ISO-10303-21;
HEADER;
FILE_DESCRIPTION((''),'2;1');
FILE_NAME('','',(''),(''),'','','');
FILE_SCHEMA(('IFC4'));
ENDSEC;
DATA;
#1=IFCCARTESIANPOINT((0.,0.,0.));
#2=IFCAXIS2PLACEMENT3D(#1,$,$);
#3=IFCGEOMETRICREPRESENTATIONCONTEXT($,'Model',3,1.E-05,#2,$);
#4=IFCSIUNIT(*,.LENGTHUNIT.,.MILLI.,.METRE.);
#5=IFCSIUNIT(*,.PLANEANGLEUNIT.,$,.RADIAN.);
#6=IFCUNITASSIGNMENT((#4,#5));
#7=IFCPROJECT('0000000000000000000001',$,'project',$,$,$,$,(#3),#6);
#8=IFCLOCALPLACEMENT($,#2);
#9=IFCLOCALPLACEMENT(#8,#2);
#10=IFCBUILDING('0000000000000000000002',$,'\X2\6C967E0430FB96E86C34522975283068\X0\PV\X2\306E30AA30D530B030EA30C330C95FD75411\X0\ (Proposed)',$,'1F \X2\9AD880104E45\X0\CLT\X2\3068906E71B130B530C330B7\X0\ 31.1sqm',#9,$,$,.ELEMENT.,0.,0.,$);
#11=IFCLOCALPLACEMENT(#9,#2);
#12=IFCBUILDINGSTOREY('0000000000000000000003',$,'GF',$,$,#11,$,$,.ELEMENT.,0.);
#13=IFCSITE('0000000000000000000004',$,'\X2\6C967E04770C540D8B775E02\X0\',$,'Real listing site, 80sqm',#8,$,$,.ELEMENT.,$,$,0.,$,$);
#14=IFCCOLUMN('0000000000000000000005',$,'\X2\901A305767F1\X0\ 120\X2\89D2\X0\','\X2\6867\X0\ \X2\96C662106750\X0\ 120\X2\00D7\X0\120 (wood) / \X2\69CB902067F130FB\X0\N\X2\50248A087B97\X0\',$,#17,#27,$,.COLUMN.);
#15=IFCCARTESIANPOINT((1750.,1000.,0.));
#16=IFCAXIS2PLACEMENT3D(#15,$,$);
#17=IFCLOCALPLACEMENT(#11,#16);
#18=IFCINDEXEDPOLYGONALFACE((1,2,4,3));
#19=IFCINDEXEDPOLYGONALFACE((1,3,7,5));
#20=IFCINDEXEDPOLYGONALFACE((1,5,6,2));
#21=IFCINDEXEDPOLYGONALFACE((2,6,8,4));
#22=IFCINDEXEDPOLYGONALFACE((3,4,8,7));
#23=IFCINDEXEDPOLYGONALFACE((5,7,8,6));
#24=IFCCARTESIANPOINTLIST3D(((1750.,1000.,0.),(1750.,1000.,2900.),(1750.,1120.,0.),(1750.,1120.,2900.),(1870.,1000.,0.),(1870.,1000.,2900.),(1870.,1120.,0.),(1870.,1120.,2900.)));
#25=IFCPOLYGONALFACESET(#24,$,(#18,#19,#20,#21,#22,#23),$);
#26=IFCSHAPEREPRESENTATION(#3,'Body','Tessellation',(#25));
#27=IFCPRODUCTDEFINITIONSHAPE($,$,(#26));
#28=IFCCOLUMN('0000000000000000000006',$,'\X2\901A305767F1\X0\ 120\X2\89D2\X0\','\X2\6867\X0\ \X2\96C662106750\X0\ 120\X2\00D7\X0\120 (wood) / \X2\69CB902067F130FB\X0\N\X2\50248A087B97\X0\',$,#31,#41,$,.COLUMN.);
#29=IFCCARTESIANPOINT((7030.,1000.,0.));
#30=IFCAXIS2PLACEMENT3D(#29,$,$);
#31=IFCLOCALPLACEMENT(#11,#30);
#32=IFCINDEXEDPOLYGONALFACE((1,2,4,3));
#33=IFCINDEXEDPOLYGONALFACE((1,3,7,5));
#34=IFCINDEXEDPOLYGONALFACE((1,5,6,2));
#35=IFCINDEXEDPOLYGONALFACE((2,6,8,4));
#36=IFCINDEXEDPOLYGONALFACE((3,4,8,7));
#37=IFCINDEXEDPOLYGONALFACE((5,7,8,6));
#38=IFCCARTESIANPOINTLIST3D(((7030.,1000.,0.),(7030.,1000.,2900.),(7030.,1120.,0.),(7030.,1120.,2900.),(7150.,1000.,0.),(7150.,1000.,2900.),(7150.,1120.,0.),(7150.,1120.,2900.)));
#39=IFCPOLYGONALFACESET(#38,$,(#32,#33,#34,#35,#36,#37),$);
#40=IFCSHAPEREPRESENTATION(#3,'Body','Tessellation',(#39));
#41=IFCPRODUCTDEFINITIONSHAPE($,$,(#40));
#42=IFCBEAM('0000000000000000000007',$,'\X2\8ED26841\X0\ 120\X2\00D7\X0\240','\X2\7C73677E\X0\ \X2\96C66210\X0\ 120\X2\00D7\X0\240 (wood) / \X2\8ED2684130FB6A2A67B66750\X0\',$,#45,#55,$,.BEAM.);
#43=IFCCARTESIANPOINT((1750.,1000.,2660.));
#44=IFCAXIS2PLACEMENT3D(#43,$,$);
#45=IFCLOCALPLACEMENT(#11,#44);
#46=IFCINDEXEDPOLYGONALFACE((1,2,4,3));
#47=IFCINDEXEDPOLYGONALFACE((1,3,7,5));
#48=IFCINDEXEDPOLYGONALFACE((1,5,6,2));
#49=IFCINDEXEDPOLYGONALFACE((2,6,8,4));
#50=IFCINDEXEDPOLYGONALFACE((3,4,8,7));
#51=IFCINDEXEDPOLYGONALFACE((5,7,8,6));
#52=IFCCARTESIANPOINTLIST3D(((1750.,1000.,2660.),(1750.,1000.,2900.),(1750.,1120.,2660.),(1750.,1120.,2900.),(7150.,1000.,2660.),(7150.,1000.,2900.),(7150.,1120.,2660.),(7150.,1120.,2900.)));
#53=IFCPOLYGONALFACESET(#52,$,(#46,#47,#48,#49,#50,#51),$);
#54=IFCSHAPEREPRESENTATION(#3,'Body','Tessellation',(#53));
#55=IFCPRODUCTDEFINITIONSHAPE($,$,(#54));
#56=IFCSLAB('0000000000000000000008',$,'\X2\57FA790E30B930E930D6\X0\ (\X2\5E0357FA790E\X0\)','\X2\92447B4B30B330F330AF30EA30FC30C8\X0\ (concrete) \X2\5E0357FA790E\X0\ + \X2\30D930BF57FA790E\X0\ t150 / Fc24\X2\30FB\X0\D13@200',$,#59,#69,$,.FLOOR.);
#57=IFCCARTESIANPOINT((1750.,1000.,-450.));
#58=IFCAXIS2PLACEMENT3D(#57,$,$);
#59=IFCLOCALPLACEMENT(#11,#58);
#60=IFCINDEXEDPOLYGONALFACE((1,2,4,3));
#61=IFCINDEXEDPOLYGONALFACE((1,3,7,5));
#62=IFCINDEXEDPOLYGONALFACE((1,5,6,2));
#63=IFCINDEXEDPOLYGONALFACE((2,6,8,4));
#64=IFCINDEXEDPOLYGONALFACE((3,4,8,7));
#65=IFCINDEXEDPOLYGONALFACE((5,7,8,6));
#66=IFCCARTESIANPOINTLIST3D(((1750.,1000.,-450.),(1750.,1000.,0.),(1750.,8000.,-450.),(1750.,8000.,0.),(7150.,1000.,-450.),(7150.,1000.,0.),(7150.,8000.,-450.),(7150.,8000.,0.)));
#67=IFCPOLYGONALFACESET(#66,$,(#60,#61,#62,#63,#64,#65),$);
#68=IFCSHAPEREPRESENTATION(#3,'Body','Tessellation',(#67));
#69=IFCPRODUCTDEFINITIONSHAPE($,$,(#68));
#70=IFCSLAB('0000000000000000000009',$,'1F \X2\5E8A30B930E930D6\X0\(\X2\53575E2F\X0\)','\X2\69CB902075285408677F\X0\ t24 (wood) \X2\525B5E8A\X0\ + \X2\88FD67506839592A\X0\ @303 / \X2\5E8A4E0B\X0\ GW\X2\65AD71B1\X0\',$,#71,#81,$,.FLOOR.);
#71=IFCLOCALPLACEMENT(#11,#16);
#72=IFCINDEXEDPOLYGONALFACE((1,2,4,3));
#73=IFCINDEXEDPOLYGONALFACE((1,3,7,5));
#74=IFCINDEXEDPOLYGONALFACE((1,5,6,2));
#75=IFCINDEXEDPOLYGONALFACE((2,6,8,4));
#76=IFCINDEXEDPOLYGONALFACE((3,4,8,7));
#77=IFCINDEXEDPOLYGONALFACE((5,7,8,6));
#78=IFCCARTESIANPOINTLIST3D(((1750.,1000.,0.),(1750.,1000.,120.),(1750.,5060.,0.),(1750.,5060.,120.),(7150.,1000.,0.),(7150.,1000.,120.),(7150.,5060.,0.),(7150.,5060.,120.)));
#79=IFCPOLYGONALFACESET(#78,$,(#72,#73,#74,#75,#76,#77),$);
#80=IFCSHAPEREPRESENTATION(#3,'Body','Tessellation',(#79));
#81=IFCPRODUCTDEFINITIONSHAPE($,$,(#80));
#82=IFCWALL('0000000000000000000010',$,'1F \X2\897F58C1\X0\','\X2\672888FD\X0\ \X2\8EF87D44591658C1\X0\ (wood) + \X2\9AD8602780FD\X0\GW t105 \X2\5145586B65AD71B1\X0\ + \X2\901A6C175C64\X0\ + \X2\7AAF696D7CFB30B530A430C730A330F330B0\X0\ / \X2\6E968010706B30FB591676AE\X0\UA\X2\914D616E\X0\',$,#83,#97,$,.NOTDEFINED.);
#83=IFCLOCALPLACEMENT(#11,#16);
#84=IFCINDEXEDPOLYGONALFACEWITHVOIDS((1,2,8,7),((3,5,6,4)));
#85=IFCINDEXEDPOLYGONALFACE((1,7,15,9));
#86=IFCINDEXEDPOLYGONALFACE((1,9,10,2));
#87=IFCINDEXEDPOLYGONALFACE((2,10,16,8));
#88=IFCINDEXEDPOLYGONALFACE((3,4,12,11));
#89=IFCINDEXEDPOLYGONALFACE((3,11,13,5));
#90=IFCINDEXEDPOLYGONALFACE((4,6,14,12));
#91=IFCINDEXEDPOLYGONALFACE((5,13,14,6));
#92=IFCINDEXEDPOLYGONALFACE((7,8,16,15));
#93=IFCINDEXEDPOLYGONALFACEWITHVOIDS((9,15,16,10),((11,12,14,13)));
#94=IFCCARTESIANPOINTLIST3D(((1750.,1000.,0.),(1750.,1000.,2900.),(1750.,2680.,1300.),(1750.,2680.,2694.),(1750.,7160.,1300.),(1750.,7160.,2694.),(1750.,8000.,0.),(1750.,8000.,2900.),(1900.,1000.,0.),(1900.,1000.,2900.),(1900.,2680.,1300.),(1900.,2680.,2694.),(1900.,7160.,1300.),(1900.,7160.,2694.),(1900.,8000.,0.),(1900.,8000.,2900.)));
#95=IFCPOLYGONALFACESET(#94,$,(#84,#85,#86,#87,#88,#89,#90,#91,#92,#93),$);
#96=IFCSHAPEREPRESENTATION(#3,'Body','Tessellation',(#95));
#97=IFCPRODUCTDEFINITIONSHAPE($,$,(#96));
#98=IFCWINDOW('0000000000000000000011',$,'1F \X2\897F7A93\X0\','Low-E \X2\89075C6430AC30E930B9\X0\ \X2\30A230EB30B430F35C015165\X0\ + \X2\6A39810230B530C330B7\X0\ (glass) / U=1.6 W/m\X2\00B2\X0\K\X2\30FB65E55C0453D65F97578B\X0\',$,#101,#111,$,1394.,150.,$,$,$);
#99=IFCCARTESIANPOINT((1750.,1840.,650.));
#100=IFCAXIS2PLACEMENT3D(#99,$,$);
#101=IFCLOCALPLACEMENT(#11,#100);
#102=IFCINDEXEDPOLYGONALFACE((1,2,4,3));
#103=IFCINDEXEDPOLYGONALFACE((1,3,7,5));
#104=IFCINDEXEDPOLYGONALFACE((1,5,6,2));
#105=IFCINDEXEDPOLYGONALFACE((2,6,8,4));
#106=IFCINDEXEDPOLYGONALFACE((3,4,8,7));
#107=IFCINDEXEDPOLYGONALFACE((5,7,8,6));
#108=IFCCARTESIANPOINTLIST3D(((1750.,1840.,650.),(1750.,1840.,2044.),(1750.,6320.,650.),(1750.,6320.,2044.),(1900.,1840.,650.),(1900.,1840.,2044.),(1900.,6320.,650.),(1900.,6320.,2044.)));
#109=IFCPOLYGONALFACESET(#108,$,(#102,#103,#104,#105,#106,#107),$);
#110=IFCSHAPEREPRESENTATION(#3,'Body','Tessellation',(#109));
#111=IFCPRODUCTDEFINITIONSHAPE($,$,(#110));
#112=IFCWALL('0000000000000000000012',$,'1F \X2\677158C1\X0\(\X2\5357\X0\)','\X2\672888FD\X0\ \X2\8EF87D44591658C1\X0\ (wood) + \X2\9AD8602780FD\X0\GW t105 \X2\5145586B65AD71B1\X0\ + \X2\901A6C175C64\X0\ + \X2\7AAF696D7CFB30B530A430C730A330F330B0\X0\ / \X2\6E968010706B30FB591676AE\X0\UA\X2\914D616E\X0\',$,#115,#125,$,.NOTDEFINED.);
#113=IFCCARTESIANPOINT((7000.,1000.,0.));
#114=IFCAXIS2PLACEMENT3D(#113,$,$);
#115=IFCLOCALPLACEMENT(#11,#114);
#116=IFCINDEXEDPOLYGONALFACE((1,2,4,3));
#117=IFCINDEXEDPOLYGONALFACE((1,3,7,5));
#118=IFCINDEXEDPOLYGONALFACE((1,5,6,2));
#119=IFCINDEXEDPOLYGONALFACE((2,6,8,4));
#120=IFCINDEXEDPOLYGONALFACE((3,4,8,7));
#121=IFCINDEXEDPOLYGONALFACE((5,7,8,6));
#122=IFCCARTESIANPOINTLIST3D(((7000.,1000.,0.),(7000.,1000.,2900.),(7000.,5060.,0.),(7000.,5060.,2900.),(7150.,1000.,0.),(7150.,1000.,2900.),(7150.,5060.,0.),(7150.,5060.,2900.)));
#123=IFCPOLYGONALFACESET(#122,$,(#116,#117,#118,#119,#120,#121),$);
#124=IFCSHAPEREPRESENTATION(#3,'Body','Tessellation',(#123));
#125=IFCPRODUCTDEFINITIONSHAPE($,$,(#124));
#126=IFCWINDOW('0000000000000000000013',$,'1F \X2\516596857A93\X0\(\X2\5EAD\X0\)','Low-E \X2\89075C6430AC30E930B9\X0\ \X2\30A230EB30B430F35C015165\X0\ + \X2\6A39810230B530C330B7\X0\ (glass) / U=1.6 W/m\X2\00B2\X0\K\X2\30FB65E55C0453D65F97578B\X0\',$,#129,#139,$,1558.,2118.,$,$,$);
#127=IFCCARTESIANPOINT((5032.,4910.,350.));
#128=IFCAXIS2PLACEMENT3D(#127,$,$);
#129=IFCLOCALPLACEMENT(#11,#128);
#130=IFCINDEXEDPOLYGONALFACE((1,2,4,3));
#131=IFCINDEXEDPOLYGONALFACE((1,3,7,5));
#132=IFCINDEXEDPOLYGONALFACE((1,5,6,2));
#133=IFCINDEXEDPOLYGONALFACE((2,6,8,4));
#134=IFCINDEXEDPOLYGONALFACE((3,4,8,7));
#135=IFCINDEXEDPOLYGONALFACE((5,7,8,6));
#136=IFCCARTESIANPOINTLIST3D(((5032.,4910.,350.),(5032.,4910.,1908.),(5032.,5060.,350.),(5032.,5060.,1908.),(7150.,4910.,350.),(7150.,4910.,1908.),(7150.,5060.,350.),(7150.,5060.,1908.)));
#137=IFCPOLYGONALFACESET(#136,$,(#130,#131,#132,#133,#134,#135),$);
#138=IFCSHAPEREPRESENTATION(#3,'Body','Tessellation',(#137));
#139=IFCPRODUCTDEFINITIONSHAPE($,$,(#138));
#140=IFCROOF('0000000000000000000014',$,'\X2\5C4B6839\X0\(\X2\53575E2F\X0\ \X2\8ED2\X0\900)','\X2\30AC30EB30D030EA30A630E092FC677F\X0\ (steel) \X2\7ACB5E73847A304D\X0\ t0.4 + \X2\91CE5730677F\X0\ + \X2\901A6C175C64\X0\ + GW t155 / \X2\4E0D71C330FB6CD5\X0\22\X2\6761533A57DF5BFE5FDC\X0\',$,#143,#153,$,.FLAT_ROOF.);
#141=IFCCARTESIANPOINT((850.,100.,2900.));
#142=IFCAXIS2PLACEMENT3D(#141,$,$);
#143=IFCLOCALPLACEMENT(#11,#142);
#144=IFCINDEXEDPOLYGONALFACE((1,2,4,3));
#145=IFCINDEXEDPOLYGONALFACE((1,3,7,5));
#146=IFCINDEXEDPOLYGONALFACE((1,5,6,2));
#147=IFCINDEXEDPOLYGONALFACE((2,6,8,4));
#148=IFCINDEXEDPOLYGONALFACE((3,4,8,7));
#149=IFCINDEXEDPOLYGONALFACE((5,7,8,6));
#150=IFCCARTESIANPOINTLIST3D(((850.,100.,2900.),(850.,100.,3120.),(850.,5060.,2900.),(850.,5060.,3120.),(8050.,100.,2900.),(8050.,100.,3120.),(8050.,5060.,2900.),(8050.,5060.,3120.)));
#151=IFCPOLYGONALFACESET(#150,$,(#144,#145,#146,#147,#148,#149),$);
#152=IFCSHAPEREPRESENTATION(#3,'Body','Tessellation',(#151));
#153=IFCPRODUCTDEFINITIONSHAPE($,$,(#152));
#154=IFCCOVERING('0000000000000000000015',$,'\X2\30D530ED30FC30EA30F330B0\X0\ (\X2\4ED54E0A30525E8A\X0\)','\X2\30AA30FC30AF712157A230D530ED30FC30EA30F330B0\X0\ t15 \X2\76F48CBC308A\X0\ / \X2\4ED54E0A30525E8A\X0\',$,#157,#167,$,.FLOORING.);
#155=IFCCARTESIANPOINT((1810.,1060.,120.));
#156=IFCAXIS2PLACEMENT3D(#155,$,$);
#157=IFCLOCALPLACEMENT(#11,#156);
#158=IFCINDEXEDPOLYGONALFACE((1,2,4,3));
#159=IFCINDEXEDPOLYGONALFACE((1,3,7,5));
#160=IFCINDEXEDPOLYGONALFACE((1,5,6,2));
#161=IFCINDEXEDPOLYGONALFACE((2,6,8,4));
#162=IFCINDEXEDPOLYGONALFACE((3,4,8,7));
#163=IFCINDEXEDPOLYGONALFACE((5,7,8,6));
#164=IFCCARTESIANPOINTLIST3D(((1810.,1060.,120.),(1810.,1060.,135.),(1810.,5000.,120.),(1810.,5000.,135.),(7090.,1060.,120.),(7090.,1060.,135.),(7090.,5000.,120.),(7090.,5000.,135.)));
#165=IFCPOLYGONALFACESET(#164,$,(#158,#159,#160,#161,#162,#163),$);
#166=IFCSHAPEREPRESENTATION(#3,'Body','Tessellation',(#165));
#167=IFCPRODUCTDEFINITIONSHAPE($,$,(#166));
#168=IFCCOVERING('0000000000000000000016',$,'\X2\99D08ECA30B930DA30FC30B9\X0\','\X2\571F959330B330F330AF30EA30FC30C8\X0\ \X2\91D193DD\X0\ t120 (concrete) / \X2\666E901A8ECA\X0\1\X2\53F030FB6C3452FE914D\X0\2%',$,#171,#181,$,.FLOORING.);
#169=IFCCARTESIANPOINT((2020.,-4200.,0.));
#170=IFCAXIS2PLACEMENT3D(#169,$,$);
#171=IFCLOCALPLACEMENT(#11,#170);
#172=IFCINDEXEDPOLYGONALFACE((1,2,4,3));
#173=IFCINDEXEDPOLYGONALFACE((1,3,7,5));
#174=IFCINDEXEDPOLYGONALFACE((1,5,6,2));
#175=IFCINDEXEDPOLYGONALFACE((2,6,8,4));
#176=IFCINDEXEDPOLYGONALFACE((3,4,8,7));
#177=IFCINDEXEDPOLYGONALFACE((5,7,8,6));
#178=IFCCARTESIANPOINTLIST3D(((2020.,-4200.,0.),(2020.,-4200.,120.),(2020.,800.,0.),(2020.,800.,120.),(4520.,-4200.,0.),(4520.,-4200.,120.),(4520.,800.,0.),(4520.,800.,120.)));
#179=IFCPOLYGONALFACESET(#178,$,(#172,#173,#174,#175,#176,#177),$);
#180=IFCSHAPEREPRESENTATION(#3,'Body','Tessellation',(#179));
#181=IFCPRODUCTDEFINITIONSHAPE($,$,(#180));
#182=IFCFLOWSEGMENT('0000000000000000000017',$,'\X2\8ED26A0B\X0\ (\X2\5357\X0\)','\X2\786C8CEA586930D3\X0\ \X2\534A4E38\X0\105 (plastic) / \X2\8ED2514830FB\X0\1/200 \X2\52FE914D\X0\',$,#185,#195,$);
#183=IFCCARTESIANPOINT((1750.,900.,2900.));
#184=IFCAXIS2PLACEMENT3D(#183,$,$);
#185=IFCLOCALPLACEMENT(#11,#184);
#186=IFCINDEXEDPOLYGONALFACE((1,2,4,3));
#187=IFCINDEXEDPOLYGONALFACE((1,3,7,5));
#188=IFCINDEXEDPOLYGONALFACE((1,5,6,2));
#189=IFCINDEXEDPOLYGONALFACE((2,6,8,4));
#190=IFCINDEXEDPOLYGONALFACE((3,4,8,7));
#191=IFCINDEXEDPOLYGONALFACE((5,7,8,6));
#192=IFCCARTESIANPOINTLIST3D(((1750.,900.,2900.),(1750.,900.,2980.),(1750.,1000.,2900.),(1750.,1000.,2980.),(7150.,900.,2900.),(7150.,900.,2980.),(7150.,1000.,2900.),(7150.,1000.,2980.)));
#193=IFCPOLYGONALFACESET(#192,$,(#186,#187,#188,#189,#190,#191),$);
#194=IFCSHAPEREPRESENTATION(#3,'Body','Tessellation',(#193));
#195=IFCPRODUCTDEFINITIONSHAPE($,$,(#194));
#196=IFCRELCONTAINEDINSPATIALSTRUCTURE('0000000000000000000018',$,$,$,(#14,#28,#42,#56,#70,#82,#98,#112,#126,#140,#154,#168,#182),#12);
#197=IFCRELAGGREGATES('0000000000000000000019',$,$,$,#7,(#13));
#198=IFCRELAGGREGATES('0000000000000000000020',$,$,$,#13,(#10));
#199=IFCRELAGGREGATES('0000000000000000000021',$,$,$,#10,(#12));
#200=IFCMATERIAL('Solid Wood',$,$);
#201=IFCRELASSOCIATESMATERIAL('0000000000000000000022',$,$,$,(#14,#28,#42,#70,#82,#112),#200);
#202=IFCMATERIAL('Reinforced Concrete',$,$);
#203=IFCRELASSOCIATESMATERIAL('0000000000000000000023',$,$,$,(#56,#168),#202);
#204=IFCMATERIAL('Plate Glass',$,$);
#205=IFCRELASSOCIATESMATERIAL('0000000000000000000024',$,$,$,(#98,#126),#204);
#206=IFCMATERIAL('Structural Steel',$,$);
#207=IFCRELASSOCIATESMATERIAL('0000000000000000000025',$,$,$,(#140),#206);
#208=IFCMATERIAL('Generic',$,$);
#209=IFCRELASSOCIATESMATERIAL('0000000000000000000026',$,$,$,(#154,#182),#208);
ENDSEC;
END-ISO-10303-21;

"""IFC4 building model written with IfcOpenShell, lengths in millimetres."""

from ifc_helpers import new_model, si_unit, frame, frame_2d, origin, place, context, project, spatial, rectangle, extrude, material, element, fill, save


model = new_model("IFC4")

# Units and contexts
model_context = context("Model", 3, precision=1e-05, world=origin())
ifc_project = project(units=[si_unit("LENGTHUNIT", "METRE", prefix="MILLI"), si_unit("PLANEANGLEUNIT", "RADIAN")], contexts=[model_context])

# Site, building, storey
site_placement = place(None, origin())
site = spatial("IfcSite", under=ifc_project, at=site_placement, Name="沖縄県名護市", ObjectType="Real listing site, 80sqm", CompositionType="ELEMENT", RefElevation=0.0)
building_placement = place(site_placement, origin())
building = spatial("IfcBuilding", under=site, at=building_placement, Name="沖縄・雨水利用とPVのオフグリッド志向 (Proposed)", ObjectType="1F 高耐久CLTと遮熱サッシ 31.1sqm", CompositionType="ELEMENT", ElevationOfRefHeight=0.0, ElevationOfTerrain=0.0)
storey_placement = place(building_placement, origin())
storey = spatial("IfcBuildingStorey", under=building, at=storey_placement, Name="GF", CompositionType="ELEMENT", Elevation=0.0)

# Columns
ifc_material_1 = material(Name="Solid Wood")
column_1_placement = place(storey_placement, frame((1750.0, 1000.0, 0.0)))
element("IfcColumn", 1, at=column_1_placement, inside=storey, material=ifc_material_1, Name="通し柱 120角", Description="桧 集成材 120×120 (wood) / 構造柱・N値計算", PredefinedType="COLUMN", context=model_context, shape_type="SweptSolid", body=[
    extrude(rectangle(XDim=120.0, YDim=120.0, at=frame_2d((60.0, 60.0))), frame((1750.0, 1000.0, 0.0)), (0.0, 0.0, 1.0), 2900.0),
])
column_2_placement = place(storey_placement, frame((7030.0, 1000.0, 0.0)))
element("IfcColumn", 2, at=column_2_placement, inside=storey, material=ifc_material_1, Name="通し柱 120角", Description="桧 集成材 120×120 (wood) / 構造柱・N値計算", PredefinedType="COLUMN", context=model_context, shape_type="SweptSolid", body=[
    extrude(rectangle(XDim=120.0, YDim=120.0, at=frame_2d((60.0, 60.0))), frame((7030.0, 1000.0, 0.0)), (0.0, 0.0, 1.0), 2900.0),
])

# Beam
beam_1_placement = place(storey_placement, frame((1750.0, 1000.0, 2660.0)))
element("IfcBeam", 3, at=beam_1_placement, inside=storey, material=ifc_material_1, Name="軒桁 120×240", Description="米松 集成 120×240 (wood) / 軒桁・横架材", PredefinedType="BEAM", context=model_context, shape_type="SweptSolid", body=[
    extrude(rectangle(XDim=5400.0, YDim=120.0, at=frame_2d((2700.0, 60.0))), frame((1750.0, 1000.0, 2660.0)), (0.0, 0.0, 1.0), 240.0),
])

# Slabs
ifc_material_2 = material(Name="Reinforced Concrete")
slab_1_placement = place(storey_placement, frame((1750.0, 1000.0, -450.0)))
element("IfcSlab", 4, at=slab_1_placement, inside=storey, material=ifc_material_2, Name="基礎スラブ (布基礎)", Description="鉄筋コンクリート (concrete) 布基礎 + ベタ基礎 t150 / Fc24・D13@200", PredefinedType="FLOOR", context=model_context, shape_type="SweptSolid", body=[
    extrude(rectangle(XDim=5400.0, YDim=7000.0, at=frame_2d((2700.0, 3500.0))), frame((1750.0, 1000.0, -450.0)), (0.0, 0.0, 1.0), 450.0),
])
slab_2_placement = place(storey_placement, frame((1750.0, 1000.0, 0.0)))
element("IfcSlab", 5, at=slab_2_placement, inside=storey, material=ifc_material_1, Name="1F 床スラブ(南帯)", Description="構造用合板 t24 (wood) 剛床 + 製材根太 @303 / 床下 GW断熱", PredefinedType="FLOOR", context=model_context, shape_type="SweptSolid", body=[
    extrude(rectangle(XDim=5400.0, YDim=4060.0, at=frame_2d((2700.0, 2030.0))), frame((1750.0, 1000.0, 0.0)), (0.0, 0.0, 1.0), 120.0),
])

# Shared definitions
ifc_material_3 = material(Name="Plate Glass")

# Walls, openings, windows
wall_1_placement = place(storey_placement, frame((1750.0, 1000.0, 0.0)))
wall_1 = element("IfcWall", 6, at=wall_1_placement, inside=storey, material=ifc_material_1, Name="1F 西壁", Description="木製 軸組外壁 (wood) + 高性能GW t105 充填断熱 + 通気層 + 窯業系サイディング / 準耐火・外皮UA配慮", PredefinedType="NOTDEFINED", context=model_context, shape_type="SweptSolid", body=[
    extrude(rectangle(XDim=150.0, YDim=7000.0, at=frame_2d((75.0, 3500.0))), frame((1750.0, 1000.0, 0.0)), (0.0, 0.0, 1.0), 2900.0),
])
opening_1_placement = place(storey_placement, frame((1750.0, 1840.0, 650.0)))
opening_1 = element("IfcOpeningElement", 7, at=opening_1_placement, cuts=wall_1, PredefinedType="NOTDEFINED", context=model_context, shape_type="SweptSolid", body=[
    extrude(rectangle(XDim=150.0, YDim=4480.0, at=frame_2d((75.0, 2240.0))), frame((1750.0, 1840.0, 650.0)), (0.0, 0.0, 1.0), 1394.0),
])
window_1_placement = place(storey_placement, frame((1750.0, 1840.0, 650.0)))
window_1 = element("IfcWindow", 8, at=window_1_placement, inside=storey, material=ifc_material_3, Name="1F 西窓", Description="Low-E 複層ガラス アルゴン封入 + 樹脂サッシ (glass) / U=1.6 W/m²K・日射取得型", OverallHeight=1394.0, OverallWidth=150.0, context=model_context, shape_type="SweptSolid", body=[
    extrude(rectangle(XDim=150.0, YDim=4480.0, at=frame_2d((75.0, 2240.0))), frame((1750.0, 1840.0, 650.0)), (0.0, 0.0, 1.0), 1394.0),
])
fill(opening_1, window_1)
wall_2_placement = place(storey_placement, frame((7000.0, 1000.0, 0.0)))
wall_2 = element("IfcWall", 9, at=wall_2_placement, inside=storey, material=ifc_material_1, Name="1F 東壁(南)", Description="木製 軸組外壁 (wood) + 高性能GW t105 充填断熱 + 通気層 + 窯業系サイディング / 準耐火・外皮UA配慮", PredefinedType="NOTDEFINED", context=model_context, shape_type="SweptSolid", body=[
    extrude(rectangle(XDim=150.0, YDim=4060.0, at=frame_2d((75.0, 2030.0))), frame((7000.0, 1000.0, 0.0)), (0.0, 0.0, 1.0), 2900.0),
])
opening_2_placement = place(storey_placement, frame((5032.0, 4910.0, 350.0)))
opening_2 = element("IfcOpeningElement", 10, at=opening_2_placement, cuts=wall_2, PredefinedType="NOTDEFINED", context=model_context, shape_type="SweptSolid", body=[
    extrude(rectangle(XDim=2118.0, YDim=150.0, at=frame_2d((1059.0, 75.0))), frame((5032.0, 4910.0, 350.0)), (0.0, 0.0, 1.0), 1558.0),
])
window_2_placement = place(storey_placement, frame((5032.0, 4910.0, 350.0)))
window_2 = element("IfcWindow", 11, at=window_2_placement, inside=storey, material=ifc_material_3, Name="1F 入隅窓(庭)", Description="Low-E 複層ガラス アルゴン封入 + 樹脂サッシ (glass) / U=1.6 W/m²K・日射取得型", OverallHeight=1558.0, OverallWidth=2118.0, context=model_context, shape_type="SweptSolid", body=[
    extrude(rectangle(XDim=2118.0, YDim=150.0, at=frame_2d((1059.0, 75.0))), frame((5032.0, 4910.0, 350.0)), (0.0, 0.0, 1.0), 1558.0),
])
fill(opening_2, window_2)

# Roof
ifc_material_4 = material(Name="Structural Steel")
roof_placement = place(storey_placement, frame((850.0, 100.0, 2900.0)))
element("IfcRoof", 12, at=roof_placement, inside=storey, material=ifc_material_4, Name="屋根(南帯 軒900)", Description="ガルバリウム鋼板 (steel) 立平葺き t0.4 + 野地板 + 通気層 + GW t155 / 不燃・法22条区域対応", PredefinedType="FLAT_ROOF", context=model_context, shape_type="SweptSolid", body=[
    extrude(rectangle(XDim=7200.0, YDim=4960.0, at=frame_2d((3600.0, 2480.0))), frame((850.0, 100.0, 2900.0)), (0.0, 0.0, 1.0), 220.0),
])

# Coverings
ifc_material_5 = material(Name="Generic")
covering_1_placement = place(storey_placement, frame((1810.0, 1060.0, 120.0)))
element("IfcCovering", 13, at=covering_1_placement, inside=storey, material=ifc_material_5, Name="フローリング (仕上げ床)", Description="オーク無垢フローリング t15 直貼り / 仕上げ床", PredefinedType="FLOORING", context=model_context, shape_type="SweptSolid", body=[
    extrude(rectangle(XDim=5280.0, YDim=3940.0, at=frame_2d((2640.0, 1970.0))), frame((1810.0, 1060.0, 120.0)), (0.0, 0.0, 1.0), 15.0),
])
covering_2_placement = place(storey_placement, frame((2020.0, -4200.0, 0.0)))
element("IfcCovering", 14, at=covering_2_placement, inside=storey, material=ifc_material_2, Name="駐車スペース", Description="土間コンクリート 金鏝 t120 (concrete) / 普通車1台・水勾配2%", PredefinedType="FLOORING", context=model_context, shape_type="SweptSolid", body=[
    extrude(rectangle(XDim=2500.0, YDim=5000.0, at=frame_2d((1250.0, 2500.0))), frame((2020.0, -4200.0, 0.0)), (0.0, 0.0, 1.0), 120.0),
])

# Flow segment
flow_segment_1_placement = place(storey_placement, frame((1750.0, 900.0, 2900.0)))
element("IfcFlowSegment", 15, at=flow_segment_1_placement, inside=storey, material=ifc_material_5, Name="軒樋 (南)", Description="硬質塩ビ 半丸105 (plastic) / 軒先・1/200 勾配", context=model_context, shape_type="SweptSolid", body=[
    extrude(rectangle(XDim=5400.0, YDim=100.0, at=frame_2d((2700.0, 50.0))), frame((1750.0, 900.0, 2900.0)), (0.0, 0.0, 1.0), 80.0),
])

save(model, "model.ifc")
